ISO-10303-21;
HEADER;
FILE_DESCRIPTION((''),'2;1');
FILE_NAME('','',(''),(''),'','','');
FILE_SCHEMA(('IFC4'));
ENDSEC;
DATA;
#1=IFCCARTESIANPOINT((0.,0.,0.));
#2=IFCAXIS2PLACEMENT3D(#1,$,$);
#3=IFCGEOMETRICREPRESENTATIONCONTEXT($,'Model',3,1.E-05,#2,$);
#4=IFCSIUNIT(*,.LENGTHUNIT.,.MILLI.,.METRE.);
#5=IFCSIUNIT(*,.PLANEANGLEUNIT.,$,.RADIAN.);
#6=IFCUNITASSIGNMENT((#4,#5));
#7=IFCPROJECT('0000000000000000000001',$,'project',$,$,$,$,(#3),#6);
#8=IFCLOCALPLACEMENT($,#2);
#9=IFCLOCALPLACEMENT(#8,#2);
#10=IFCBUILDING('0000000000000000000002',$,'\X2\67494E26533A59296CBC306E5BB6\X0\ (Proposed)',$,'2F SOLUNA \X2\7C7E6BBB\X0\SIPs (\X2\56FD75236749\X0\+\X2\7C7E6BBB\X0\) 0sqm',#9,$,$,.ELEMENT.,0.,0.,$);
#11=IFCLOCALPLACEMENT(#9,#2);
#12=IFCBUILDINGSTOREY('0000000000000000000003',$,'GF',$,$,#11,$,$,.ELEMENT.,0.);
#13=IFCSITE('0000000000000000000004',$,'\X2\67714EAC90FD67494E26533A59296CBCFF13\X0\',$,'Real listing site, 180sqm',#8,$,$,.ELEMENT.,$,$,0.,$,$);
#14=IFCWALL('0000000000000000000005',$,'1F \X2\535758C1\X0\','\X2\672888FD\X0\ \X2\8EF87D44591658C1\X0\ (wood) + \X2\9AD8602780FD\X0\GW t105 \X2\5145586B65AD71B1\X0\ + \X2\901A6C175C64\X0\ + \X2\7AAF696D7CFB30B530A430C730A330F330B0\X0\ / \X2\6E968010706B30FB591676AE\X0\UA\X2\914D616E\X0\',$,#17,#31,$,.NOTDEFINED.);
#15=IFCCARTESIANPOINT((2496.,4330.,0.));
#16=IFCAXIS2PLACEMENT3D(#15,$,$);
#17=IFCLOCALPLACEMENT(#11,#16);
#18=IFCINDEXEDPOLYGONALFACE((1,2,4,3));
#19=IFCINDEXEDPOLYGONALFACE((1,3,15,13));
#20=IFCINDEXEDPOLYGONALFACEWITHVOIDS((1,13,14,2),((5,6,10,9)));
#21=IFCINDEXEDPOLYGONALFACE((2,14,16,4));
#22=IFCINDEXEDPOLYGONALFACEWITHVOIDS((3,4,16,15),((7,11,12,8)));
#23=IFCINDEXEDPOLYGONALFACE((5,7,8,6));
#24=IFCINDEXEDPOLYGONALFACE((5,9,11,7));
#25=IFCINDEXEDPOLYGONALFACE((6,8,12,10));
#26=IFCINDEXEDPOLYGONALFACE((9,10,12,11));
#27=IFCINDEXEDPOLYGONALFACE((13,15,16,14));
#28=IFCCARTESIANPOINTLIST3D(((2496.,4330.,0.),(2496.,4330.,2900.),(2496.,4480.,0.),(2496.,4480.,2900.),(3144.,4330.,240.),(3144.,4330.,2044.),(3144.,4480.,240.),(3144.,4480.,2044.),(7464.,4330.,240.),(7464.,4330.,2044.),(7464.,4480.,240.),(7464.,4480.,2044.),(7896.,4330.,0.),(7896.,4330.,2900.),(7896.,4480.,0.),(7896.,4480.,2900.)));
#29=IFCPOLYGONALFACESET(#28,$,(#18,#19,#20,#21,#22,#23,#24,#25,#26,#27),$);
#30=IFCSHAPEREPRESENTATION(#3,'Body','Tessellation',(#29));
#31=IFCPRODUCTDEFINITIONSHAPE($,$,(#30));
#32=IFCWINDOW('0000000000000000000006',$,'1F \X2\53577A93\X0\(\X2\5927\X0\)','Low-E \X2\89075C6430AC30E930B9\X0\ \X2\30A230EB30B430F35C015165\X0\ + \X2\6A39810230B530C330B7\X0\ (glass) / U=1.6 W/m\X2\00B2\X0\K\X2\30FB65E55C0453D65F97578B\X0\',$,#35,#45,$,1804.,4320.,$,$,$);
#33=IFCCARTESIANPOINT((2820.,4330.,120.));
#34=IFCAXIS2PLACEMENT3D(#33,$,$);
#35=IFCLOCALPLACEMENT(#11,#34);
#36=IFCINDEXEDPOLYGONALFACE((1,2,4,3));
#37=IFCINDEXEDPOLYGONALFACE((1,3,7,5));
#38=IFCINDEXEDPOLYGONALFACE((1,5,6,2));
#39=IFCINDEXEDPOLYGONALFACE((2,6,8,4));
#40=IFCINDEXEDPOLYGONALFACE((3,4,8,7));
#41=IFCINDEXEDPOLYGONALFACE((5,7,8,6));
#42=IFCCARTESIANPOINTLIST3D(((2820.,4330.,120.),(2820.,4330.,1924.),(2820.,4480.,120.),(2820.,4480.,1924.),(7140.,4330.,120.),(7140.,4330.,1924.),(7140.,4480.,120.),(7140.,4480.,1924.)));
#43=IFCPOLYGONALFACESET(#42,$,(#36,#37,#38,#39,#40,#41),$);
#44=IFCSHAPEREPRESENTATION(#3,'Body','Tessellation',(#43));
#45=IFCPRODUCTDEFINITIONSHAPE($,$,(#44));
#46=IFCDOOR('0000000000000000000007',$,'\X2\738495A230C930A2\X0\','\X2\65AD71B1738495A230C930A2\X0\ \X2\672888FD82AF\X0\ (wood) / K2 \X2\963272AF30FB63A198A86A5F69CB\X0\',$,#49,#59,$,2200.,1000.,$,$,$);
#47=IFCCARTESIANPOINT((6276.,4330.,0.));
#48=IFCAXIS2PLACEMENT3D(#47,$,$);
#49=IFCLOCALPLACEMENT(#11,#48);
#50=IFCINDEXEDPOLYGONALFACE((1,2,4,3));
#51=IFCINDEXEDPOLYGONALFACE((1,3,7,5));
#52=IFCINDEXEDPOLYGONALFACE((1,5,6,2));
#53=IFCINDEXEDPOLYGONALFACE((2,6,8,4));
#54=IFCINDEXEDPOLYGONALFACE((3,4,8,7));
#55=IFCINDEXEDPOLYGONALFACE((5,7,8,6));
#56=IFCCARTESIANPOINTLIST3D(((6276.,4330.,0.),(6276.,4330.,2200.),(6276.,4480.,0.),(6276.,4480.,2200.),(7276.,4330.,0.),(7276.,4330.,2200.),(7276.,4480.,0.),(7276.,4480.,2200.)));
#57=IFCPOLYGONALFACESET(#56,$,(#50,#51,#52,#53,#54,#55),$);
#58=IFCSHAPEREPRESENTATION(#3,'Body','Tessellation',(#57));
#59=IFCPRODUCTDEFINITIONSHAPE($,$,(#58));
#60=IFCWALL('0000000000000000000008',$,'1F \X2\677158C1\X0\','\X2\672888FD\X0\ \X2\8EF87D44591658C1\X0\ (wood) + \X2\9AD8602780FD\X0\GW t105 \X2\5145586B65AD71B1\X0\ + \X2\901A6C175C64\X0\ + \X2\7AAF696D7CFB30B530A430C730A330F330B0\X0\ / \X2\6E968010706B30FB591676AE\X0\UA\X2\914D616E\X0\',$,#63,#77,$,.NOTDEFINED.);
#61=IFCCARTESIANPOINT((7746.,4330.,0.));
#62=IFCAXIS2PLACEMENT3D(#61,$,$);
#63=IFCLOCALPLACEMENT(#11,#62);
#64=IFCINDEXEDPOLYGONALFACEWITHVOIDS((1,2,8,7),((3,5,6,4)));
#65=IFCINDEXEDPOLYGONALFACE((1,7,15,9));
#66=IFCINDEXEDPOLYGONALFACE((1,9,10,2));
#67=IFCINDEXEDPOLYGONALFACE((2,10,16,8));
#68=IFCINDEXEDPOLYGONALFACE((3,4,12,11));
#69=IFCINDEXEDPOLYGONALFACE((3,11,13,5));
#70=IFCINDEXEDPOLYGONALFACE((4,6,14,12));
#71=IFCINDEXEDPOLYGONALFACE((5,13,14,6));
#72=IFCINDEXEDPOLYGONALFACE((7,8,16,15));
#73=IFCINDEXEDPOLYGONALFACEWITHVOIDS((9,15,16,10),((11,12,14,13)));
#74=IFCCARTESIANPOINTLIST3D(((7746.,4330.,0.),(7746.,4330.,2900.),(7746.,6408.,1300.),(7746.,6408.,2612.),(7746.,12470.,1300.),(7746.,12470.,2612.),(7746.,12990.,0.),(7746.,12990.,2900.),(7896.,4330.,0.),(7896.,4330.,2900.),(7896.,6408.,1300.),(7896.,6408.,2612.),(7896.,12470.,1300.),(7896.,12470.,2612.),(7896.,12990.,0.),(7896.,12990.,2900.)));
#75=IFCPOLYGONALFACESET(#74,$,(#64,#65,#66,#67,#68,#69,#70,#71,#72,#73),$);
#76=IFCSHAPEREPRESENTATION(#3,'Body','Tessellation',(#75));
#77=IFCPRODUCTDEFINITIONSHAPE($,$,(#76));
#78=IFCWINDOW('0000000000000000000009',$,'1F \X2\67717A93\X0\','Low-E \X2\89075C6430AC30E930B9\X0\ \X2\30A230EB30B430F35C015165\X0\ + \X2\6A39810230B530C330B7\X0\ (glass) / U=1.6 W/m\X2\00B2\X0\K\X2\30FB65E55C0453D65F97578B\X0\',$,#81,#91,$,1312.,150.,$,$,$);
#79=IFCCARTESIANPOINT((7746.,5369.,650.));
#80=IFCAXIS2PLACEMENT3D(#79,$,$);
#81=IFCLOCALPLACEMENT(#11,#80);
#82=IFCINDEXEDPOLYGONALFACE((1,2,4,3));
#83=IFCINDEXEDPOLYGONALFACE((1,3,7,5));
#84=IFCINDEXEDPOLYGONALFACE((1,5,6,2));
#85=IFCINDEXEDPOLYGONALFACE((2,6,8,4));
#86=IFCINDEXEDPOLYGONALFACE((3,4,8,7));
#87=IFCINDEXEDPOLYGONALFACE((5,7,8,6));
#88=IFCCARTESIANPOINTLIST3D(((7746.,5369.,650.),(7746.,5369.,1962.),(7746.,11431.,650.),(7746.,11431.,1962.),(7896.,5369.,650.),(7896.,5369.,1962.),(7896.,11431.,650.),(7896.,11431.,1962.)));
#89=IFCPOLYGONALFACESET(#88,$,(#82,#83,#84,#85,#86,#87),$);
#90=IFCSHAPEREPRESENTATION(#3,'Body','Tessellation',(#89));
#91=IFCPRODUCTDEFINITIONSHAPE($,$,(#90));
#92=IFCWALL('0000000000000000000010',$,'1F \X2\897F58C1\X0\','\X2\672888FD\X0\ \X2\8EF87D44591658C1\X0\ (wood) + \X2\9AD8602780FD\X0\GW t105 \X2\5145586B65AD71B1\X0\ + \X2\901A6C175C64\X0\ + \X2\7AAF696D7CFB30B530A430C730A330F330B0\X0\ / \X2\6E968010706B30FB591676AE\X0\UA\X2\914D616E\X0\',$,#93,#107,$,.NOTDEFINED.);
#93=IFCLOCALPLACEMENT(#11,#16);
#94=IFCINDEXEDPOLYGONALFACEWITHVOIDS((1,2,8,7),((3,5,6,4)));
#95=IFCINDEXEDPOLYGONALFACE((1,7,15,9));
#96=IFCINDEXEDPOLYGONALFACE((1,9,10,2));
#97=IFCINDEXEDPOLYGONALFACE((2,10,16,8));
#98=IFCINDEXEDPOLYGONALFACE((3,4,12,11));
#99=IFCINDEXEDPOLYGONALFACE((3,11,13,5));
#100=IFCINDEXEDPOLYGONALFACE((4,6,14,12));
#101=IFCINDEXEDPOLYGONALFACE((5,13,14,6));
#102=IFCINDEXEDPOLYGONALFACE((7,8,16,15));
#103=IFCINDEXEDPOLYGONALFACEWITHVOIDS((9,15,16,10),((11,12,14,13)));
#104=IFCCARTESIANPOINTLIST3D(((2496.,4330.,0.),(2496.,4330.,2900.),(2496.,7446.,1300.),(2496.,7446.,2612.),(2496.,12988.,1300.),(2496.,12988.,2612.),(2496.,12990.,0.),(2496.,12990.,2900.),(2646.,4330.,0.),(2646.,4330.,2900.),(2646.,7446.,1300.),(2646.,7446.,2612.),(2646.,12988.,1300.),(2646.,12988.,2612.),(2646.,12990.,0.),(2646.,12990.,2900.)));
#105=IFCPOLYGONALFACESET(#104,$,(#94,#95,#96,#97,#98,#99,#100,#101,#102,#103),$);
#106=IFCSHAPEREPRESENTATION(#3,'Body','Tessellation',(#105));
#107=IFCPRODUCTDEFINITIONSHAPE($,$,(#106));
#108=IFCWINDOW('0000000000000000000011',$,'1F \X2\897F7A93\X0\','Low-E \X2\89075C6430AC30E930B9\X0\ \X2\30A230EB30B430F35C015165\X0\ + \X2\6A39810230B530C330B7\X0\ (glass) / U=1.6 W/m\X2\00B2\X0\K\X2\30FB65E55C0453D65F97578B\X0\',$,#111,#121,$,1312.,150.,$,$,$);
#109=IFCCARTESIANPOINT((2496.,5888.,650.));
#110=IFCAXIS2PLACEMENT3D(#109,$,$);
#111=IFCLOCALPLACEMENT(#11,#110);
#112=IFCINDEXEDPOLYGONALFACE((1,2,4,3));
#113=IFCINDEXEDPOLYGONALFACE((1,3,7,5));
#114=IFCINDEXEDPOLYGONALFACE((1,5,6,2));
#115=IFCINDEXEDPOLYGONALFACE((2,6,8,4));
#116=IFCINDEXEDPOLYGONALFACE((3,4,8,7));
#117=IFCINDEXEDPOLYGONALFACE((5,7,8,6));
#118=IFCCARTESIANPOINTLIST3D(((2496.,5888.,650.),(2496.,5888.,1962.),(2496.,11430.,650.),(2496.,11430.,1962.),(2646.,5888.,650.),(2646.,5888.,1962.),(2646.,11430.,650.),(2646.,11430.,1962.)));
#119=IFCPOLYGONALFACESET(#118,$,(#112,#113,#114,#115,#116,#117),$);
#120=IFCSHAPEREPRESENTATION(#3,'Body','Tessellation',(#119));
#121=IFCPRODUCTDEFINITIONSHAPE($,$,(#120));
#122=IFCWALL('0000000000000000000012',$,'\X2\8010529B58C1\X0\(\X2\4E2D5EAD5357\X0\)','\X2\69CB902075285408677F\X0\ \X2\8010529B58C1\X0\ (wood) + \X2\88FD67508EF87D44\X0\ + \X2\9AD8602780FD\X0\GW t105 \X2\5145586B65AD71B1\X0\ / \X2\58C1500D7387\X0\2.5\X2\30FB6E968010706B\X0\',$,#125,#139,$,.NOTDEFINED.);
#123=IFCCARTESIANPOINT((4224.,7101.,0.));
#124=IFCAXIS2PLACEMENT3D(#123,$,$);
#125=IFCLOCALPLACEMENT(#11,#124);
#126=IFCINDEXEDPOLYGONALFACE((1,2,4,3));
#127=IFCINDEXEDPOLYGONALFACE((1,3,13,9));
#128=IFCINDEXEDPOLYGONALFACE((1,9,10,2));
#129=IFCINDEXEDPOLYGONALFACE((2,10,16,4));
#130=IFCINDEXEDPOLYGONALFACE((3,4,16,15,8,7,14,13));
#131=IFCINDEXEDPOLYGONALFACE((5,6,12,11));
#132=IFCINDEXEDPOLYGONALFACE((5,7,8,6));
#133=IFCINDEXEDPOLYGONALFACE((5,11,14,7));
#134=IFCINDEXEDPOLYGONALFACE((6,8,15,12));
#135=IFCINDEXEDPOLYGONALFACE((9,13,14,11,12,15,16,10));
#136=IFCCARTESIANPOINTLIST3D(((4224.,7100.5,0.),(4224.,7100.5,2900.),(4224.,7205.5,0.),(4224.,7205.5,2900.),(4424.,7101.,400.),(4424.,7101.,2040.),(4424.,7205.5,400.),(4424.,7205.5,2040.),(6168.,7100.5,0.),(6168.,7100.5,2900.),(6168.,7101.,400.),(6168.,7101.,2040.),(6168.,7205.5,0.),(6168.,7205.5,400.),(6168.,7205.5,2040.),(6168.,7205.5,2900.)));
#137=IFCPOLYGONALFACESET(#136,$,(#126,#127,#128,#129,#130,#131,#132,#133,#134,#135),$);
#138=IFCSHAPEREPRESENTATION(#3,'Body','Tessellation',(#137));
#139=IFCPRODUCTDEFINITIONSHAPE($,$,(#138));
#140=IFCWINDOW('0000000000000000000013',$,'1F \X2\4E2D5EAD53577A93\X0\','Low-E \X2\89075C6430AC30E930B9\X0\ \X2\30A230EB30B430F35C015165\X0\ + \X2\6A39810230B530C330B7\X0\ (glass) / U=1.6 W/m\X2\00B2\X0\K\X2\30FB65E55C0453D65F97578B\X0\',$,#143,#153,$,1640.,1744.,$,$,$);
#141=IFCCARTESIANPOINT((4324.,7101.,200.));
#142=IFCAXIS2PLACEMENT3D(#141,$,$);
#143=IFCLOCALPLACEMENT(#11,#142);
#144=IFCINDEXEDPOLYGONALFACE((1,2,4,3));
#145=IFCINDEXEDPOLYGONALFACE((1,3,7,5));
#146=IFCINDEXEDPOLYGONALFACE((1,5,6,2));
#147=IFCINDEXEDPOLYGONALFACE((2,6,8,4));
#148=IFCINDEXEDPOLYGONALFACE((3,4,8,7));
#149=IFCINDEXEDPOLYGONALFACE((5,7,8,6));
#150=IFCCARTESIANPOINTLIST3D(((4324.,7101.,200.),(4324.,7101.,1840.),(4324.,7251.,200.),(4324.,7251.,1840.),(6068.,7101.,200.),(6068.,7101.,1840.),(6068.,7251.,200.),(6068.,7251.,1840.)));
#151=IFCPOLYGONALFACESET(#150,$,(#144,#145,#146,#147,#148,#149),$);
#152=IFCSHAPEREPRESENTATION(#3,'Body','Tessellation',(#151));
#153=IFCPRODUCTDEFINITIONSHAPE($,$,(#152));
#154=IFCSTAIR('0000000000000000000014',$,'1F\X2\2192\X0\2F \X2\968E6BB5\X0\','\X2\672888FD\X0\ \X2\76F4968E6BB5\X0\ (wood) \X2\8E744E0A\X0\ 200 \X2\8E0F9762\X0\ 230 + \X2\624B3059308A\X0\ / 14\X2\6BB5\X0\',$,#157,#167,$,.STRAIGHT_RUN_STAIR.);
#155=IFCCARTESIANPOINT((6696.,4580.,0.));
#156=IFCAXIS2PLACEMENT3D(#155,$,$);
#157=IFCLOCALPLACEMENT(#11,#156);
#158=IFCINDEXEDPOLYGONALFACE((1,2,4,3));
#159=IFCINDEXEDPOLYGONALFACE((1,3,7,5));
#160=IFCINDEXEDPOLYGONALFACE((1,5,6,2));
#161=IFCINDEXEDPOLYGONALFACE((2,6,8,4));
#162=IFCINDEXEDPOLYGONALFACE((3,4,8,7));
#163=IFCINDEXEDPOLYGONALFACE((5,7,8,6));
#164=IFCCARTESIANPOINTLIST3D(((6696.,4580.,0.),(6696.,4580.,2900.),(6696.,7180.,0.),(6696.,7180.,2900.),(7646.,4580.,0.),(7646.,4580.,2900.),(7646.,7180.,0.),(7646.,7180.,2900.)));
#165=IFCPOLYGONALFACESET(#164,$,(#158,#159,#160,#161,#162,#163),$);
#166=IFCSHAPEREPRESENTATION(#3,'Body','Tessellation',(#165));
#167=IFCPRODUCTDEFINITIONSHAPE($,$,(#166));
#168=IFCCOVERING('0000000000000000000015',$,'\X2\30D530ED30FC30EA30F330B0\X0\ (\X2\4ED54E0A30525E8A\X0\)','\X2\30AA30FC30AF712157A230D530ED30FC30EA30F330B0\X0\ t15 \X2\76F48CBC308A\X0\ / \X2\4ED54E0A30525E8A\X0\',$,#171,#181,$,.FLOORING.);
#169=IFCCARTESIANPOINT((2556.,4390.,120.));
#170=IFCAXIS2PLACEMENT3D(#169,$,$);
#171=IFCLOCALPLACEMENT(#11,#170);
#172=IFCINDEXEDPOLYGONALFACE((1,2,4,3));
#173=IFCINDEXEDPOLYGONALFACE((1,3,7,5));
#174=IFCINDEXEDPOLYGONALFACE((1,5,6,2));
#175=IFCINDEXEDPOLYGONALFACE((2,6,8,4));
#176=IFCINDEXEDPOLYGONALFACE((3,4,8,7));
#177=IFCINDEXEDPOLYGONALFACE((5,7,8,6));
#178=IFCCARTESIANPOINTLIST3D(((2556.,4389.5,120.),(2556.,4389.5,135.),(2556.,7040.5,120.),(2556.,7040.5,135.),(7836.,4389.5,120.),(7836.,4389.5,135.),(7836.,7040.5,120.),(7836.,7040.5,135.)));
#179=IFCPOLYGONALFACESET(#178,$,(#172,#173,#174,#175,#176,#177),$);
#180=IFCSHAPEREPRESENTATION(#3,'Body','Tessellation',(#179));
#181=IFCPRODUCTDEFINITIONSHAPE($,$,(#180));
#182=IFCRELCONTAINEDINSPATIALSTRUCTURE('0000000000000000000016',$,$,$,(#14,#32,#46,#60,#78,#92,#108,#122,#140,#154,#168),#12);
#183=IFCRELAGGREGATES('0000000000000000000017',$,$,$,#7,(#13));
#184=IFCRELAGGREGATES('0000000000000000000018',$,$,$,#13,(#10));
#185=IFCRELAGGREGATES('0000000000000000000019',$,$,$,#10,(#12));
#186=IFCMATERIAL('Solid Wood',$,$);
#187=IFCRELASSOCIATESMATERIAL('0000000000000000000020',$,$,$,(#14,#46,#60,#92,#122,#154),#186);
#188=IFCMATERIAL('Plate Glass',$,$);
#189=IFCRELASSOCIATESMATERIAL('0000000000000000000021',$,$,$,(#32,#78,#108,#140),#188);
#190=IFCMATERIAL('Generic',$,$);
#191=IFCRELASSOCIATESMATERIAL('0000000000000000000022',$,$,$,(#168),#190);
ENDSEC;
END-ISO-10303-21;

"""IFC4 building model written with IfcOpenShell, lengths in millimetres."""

from ifc_helpers import new_model, si_unit, frame, frame_2d, origin, place, context, project, spatial, rectangle, extrude, material, element, fill, save


model = new_model("IFC4")

# Units and contexts
model_context = context("Model", 3, precision=1e-05, world=origin())
ifc_project = project(units=[si_unit("LENGTHUNIT", "METRE", prefix="MILLI"), si_unit("PLANEANGLEUNIT", "RADIAN")], contexts=[model_context])

# Site, building, storey
site_placement = place(None, origin())
site = spatial("IfcSite", under=ifc_project, at=site_placement, Name="東京都杉並区天沼３", ObjectType="Real listing site, 180sqm", CompositionType="ELEMENT", RefElevation=0.0)
building_placement = place(site_placement, origin())
building = spatial("IfcBuilding", under=site, at=building_placement, Name="杉並区天沼の家 (Proposed)", ObjectType="2F SOLUNA 籾殻SIPs (国産杉+籾殻) 0sqm", CompositionType="ELEMENT", ElevationOfRefHeight=0.0, ElevationOfTerrain=0.0)
storey_placement = place(building_placement, origin())
storey = spatial("IfcBuildingStorey", under=building, at=storey_placement, Name="GF", CompositionType="ELEMENT", Elevation=0.0)

# Shared definitions
ifc_material_1 = material(Name="Solid Wood")

# Wall, openings, window, door
wall_1_placement = place(storey_placement, frame((2496.0, 4330.0, 0.0)))
wall_1 = element("IfcWall", 1, at=wall_1_placement, inside=storey, material=ifc_material_1, Name="1F 南壁", Description="木製 軸組外壁 (wood) + 高性能GW t105 充填断熱 + 通気層 + 窯業系サイディング / 準耐火・外皮UA配慮", PredefinedType="NOTDEFINED", context=model_context, shape_type="SweptSolid", body=[
    extrude(rectangle(XDim=5400.0, YDim=150.0, at=frame_2d((2700.0, 75.0))), frame((2496.0, 4330.0, 0.0)), (0.0, 0.0, 1.0), 2900.0),
])
opening_1_placement = place(storey_placement, frame((2820.0, 4330.0, 120.0)))
opening_1 = element("IfcOpeningElement", 2, at=opening_1_placement, cuts=wall_1, PredefinedType="NOTDEFINED", context=model_context, shape_type="SweptSolid", body=[
    extrude(rectangle(XDim=4320.0, YDim=150.0, at=frame_2d((2160.0, 75.0))), frame((2820.0, 4330.0, 120.0)), (0.0, 0.0, 1.0), 1804.0),
])
opening_2_placement = place(storey_placement, frame((6276.0, 4330.0, 0.0)))
opening_2 = element("IfcOpeningElement", 3, at=opening_2_placement, cuts=wall_1, PredefinedType="NOTDEFINED", context=model_context, shape_type="SweptSolid", body=[
    extrude(rectangle(XDim=1000.0, YDim=150.0, at=frame_2d((500.0, 75.0))), frame((6276.0, 4330.0, 0.0)), (0.0, 0.0, 1.0), 2200.0),
])
ifc_material_2 = material(Name="Plate Glass")
window_1_placement = place(storey_placement, frame((2820.0, 4330.0, 120.0)))
window_1 = element("IfcWindow", 4, at=window_1_placement, inside=storey, material=ifc_material_2, Name="1F 南窓(大)", Description="Low-E 複層ガラス アルゴン封入 + 樹脂サッシ (glass) / U=1.6 W/m²K・日射取得型", OverallHeight=1804.0, OverallWidth=4320.0, context=model_context, shape_type="SweptSolid", body=[
    extrude(rectangle(XDim=4320.0, YDim=150.0, at=frame_2d((2160.0, 75.0))), frame((2820.0, 4330.0, 120.0)), (0.0, 0.0, 1.0), 1804.0),
])
fill(opening_1, window_1)
door_placement = place(storey_placement, frame((6276.0, 4330.0, 0.0)))
door = element("IfcDoor", 5, at=door_placement, inside=storey, material=ifc_material_1, Name="玄関ドア", Description="断熱玄関ドア 木製芯 (wood) / K2 防犯・採風機構", OverallHeight=2200.0, OverallWidth=1000.0, context=model_context, shape_type="SweptSolid", body=[
    extrude(rectangle(XDim=1000.0, YDim=150.0, at=frame_2d((500.0, 75.0))), frame((6276.0, 4330.0, 0.0)), (0.0, 0.0, 1.0), 2200.0),
])
fill(opening_2, door)

# Walls, openings, windows
wall_2_placement = place(storey_placement, frame((7746.0, 4330.0, 0.0)))
wall_2 = element("IfcWall", 6, at=wall_2_placement, inside=storey, material=ifc_material_1, Name="1F 東壁", Description="木製 軸組外壁 (wood) + 高性能GW t105 充填断熱 + 通気層 + 窯業系サイディング / 準耐火・外皮UA配慮", PredefinedType="NOTDEFINED", context=model_context, shape_type="SweptSolid", body=[
    extrude(rectangle(XDim=150.0, YDim=8660.0, at=frame_2d((75.0, 4330.0))), frame((7746.0, 4330.0, 0.0)), (0.0, 0.0, 1.0), 2900.0),
])
opening_3_placement = place(storey_placement, frame((7746.0, 5369.0, 650.0)))
opening_3 = element("IfcOpeningElement", 7, at=opening_3_placement, cuts=wall_2, PredefinedType="NOTDEFINED", context=model_context, shape_type="SweptSolid", body=[
    extrude(rectangle(XDim=150.0, YDim=6062.0, at=frame_2d((75.0, 3031.0))), frame((7746.0, 5369.0, 650.0)), (0.0, 0.0, 1.0), 1312.0),
])
window_2_placement = place(storey_placement, frame((7746.0, 5369.0, 650.0)))
window_2 = element("IfcWindow", 8, at=window_2_placement, inside=storey, material=ifc_material_2, Name="1F 東窓", Description="Low-E 複層ガラス アルゴン封入 + 樹脂サッシ (glass) / U=1.6 W/m²K・日射取得型", OverallHeight=1312.0, OverallWidth=150.0, context=model_context, shape_type="SweptSolid", body=[
    extrude(rectangle(XDim=150.0, YDim=6062.0, at=frame_2d((75.0, 3031.0))), frame((7746.0, 5369.0, 650.0)), (0.0, 0.0, 1.0), 1312.0),
])
fill(opening_3, window_2)
wall_3_placement = place(storey_placement, frame((2496.0, 4330.0, 0.0)))
wall_3 = element("IfcWall", 9, at=wall_3_placement, inside=storey, material=ifc_material_1, Name="1F 西壁", Description="木製 軸組外壁 (wood) + 高性能GW t105 充填断熱 + 通気層 + 窯業系サイディング / 準耐火・外皮UA配慮", PredefinedType="NOTDEFINED", context=model_context, shape_type="SweptSolid", body=[
    extrude(rectangle(XDim=150.0, YDim=8660.0, at=frame_2d((75.0, 4330.0))), frame((2496.0, 4330.0, 0.0)), (0.0, 0.0, 1.0), 2900.0),
])
opening_4_placement = place(storey_placement, frame((2496.0, 5888.0, 650.0)))
opening_4 = element("IfcOpeningElement", 10, at=opening_4_placement, cuts=wall_3, PredefinedType="NOTDEFINED", context=model_context, shape_type="SweptSolid", body=[
    extrude(rectangle(XDim=150.0, YDim=5542.0, at=frame_2d((75.0, 2771.0))), frame((2496.0, 5888.0, 650.0)), (0.0, 0.0, 1.0), 1312.0),
])
window_3_placement = place(storey_placement, frame((2496.0, 5888.0, 650.0)))
window_3 = element("IfcWindow", 11, at=window_3_placement, inside=storey, material=ifc_material_2, Name="1F 西窓", Description="Low-E 複層ガラス アルゴン封入 + 樹脂サッシ (glass) / U=1.6 W/m²K・日射取得型", OverallHeight=1312.0, OverallWidth=150.0, context=model_context, shape_type="SweptSolid", body=[
    extrude(rectangle(XDim=150.0, YDim=5542.0, at=frame_2d((75.0, 2771.0))), frame((2496.0, 5888.0, 650.0)), (0.0, 0.0, 1.0), 1312.0),
])
fill(opening_4, window_3)
wall_4_placement = place(storey_placement, frame((4224.0, 7101.0, 0.0)))
wall_4 = element("IfcWall", 12, at=wall_4_placement, inside=storey, material=ifc_material_1, Name="耐力壁(中庭南)", Description="構造用合板 耐力壁 (wood) + 製材軸組 + 高性能GW t105 充填断熱 / 壁倍率2.5・準耐火", PredefinedType="NOTDEFINED", context=model_context, shape_type="SweptSolid", body=[
    extrude(rectangle(XDim=1944.0, YDim=105.0, at=frame_2d((972.0, 52.0))), frame((4224.0, 7101.0, 0.0)), (0.0, 0.0, 1.0), 2900.0),
])
opening_5_placement = place(storey_placement, frame((4324.0, 7101.0, 200.0)))
opening_5 = element("IfcOpeningElement", 13, at=opening_5_placement, cuts=wall_4, PredefinedType="NOTDEFINED", context=model_context, shape_type="SweptSolid", body=[
    extrude(rectangle(XDim=1744.0, YDim=150.0, at=frame_2d((872.0, 75.0))), frame((4324.0, 7101.0, 200.0)), (0.0, 0.0, 1.0), 1640.0),
])
window_4_placement = place(storey_placement, frame((4324.0, 7101.0, 200.0)))
window_4 = element("IfcWindow", 14, at=window_4_placement, inside=storey, material=ifc_material_2, Name="1F 中庭南窓", Description="Low-E 複層ガラス アルゴン封入 + 樹脂サッシ (glass) / U=1.6 W/m²K・日射取得型", OverallHeight=1640.0, OverallWidth=1744.0, context=model_context, shape_type="SweptSolid", body=[
    extrude(rectangle(XDim=1744.0, YDim=150.0, at=frame_2d((872.0, 75.0))), frame((4324.0, 7101.0, 200.0)), (0.0, 0.0, 1.0), 1640.0),
])
fill(opening_5, window_4)

# Stair
stair_placement = place(storey_placement, frame((6696.0, 4580.0, 0.0)))
element("IfcStair", 15, at=stair_placement, inside=storey, material=ifc_material_1, Name="1F→2F 階段", Description="木製 直階段 (wood) 蹴上 200 踏面 230 + 手すり / 14段", PredefinedType="STRAIGHT_RUN_STAIR", context=model_context, shape_type="SweptSolid", body=[
    extrude(rectangle(XDim=950.0, YDim=2600.0, at=frame_2d((475.0, 1300.0))), frame((6696.0, 4580.0, 0.0)), (0.0, 0.0, 1.0), 2900.0),
])

# Covering
ifc_material_3 = material(Name="Generic")
covering_placement = place(storey_placement, frame((2556.0, 4390.0, 120.0)))
element("IfcCovering", 16, at=covering_placement, inside=storey, material=ifc_material_3, Name="フローリング (仕上げ床)", Description="オーク無垢フローリング t15 直貼り / 仕上げ床", PredefinedType="FLOORING", context=model_context, shape_type="SweptSolid", body=[
    extrude(rectangle(XDim=5280.0, YDim=2651.0, at=frame_2d((2640.0, 1325.0))), frame((2556.0, 4390.0, 120.0)), (0.0, 0.0, 1.0), 15.0),
])

save(model, "model.ifc")
